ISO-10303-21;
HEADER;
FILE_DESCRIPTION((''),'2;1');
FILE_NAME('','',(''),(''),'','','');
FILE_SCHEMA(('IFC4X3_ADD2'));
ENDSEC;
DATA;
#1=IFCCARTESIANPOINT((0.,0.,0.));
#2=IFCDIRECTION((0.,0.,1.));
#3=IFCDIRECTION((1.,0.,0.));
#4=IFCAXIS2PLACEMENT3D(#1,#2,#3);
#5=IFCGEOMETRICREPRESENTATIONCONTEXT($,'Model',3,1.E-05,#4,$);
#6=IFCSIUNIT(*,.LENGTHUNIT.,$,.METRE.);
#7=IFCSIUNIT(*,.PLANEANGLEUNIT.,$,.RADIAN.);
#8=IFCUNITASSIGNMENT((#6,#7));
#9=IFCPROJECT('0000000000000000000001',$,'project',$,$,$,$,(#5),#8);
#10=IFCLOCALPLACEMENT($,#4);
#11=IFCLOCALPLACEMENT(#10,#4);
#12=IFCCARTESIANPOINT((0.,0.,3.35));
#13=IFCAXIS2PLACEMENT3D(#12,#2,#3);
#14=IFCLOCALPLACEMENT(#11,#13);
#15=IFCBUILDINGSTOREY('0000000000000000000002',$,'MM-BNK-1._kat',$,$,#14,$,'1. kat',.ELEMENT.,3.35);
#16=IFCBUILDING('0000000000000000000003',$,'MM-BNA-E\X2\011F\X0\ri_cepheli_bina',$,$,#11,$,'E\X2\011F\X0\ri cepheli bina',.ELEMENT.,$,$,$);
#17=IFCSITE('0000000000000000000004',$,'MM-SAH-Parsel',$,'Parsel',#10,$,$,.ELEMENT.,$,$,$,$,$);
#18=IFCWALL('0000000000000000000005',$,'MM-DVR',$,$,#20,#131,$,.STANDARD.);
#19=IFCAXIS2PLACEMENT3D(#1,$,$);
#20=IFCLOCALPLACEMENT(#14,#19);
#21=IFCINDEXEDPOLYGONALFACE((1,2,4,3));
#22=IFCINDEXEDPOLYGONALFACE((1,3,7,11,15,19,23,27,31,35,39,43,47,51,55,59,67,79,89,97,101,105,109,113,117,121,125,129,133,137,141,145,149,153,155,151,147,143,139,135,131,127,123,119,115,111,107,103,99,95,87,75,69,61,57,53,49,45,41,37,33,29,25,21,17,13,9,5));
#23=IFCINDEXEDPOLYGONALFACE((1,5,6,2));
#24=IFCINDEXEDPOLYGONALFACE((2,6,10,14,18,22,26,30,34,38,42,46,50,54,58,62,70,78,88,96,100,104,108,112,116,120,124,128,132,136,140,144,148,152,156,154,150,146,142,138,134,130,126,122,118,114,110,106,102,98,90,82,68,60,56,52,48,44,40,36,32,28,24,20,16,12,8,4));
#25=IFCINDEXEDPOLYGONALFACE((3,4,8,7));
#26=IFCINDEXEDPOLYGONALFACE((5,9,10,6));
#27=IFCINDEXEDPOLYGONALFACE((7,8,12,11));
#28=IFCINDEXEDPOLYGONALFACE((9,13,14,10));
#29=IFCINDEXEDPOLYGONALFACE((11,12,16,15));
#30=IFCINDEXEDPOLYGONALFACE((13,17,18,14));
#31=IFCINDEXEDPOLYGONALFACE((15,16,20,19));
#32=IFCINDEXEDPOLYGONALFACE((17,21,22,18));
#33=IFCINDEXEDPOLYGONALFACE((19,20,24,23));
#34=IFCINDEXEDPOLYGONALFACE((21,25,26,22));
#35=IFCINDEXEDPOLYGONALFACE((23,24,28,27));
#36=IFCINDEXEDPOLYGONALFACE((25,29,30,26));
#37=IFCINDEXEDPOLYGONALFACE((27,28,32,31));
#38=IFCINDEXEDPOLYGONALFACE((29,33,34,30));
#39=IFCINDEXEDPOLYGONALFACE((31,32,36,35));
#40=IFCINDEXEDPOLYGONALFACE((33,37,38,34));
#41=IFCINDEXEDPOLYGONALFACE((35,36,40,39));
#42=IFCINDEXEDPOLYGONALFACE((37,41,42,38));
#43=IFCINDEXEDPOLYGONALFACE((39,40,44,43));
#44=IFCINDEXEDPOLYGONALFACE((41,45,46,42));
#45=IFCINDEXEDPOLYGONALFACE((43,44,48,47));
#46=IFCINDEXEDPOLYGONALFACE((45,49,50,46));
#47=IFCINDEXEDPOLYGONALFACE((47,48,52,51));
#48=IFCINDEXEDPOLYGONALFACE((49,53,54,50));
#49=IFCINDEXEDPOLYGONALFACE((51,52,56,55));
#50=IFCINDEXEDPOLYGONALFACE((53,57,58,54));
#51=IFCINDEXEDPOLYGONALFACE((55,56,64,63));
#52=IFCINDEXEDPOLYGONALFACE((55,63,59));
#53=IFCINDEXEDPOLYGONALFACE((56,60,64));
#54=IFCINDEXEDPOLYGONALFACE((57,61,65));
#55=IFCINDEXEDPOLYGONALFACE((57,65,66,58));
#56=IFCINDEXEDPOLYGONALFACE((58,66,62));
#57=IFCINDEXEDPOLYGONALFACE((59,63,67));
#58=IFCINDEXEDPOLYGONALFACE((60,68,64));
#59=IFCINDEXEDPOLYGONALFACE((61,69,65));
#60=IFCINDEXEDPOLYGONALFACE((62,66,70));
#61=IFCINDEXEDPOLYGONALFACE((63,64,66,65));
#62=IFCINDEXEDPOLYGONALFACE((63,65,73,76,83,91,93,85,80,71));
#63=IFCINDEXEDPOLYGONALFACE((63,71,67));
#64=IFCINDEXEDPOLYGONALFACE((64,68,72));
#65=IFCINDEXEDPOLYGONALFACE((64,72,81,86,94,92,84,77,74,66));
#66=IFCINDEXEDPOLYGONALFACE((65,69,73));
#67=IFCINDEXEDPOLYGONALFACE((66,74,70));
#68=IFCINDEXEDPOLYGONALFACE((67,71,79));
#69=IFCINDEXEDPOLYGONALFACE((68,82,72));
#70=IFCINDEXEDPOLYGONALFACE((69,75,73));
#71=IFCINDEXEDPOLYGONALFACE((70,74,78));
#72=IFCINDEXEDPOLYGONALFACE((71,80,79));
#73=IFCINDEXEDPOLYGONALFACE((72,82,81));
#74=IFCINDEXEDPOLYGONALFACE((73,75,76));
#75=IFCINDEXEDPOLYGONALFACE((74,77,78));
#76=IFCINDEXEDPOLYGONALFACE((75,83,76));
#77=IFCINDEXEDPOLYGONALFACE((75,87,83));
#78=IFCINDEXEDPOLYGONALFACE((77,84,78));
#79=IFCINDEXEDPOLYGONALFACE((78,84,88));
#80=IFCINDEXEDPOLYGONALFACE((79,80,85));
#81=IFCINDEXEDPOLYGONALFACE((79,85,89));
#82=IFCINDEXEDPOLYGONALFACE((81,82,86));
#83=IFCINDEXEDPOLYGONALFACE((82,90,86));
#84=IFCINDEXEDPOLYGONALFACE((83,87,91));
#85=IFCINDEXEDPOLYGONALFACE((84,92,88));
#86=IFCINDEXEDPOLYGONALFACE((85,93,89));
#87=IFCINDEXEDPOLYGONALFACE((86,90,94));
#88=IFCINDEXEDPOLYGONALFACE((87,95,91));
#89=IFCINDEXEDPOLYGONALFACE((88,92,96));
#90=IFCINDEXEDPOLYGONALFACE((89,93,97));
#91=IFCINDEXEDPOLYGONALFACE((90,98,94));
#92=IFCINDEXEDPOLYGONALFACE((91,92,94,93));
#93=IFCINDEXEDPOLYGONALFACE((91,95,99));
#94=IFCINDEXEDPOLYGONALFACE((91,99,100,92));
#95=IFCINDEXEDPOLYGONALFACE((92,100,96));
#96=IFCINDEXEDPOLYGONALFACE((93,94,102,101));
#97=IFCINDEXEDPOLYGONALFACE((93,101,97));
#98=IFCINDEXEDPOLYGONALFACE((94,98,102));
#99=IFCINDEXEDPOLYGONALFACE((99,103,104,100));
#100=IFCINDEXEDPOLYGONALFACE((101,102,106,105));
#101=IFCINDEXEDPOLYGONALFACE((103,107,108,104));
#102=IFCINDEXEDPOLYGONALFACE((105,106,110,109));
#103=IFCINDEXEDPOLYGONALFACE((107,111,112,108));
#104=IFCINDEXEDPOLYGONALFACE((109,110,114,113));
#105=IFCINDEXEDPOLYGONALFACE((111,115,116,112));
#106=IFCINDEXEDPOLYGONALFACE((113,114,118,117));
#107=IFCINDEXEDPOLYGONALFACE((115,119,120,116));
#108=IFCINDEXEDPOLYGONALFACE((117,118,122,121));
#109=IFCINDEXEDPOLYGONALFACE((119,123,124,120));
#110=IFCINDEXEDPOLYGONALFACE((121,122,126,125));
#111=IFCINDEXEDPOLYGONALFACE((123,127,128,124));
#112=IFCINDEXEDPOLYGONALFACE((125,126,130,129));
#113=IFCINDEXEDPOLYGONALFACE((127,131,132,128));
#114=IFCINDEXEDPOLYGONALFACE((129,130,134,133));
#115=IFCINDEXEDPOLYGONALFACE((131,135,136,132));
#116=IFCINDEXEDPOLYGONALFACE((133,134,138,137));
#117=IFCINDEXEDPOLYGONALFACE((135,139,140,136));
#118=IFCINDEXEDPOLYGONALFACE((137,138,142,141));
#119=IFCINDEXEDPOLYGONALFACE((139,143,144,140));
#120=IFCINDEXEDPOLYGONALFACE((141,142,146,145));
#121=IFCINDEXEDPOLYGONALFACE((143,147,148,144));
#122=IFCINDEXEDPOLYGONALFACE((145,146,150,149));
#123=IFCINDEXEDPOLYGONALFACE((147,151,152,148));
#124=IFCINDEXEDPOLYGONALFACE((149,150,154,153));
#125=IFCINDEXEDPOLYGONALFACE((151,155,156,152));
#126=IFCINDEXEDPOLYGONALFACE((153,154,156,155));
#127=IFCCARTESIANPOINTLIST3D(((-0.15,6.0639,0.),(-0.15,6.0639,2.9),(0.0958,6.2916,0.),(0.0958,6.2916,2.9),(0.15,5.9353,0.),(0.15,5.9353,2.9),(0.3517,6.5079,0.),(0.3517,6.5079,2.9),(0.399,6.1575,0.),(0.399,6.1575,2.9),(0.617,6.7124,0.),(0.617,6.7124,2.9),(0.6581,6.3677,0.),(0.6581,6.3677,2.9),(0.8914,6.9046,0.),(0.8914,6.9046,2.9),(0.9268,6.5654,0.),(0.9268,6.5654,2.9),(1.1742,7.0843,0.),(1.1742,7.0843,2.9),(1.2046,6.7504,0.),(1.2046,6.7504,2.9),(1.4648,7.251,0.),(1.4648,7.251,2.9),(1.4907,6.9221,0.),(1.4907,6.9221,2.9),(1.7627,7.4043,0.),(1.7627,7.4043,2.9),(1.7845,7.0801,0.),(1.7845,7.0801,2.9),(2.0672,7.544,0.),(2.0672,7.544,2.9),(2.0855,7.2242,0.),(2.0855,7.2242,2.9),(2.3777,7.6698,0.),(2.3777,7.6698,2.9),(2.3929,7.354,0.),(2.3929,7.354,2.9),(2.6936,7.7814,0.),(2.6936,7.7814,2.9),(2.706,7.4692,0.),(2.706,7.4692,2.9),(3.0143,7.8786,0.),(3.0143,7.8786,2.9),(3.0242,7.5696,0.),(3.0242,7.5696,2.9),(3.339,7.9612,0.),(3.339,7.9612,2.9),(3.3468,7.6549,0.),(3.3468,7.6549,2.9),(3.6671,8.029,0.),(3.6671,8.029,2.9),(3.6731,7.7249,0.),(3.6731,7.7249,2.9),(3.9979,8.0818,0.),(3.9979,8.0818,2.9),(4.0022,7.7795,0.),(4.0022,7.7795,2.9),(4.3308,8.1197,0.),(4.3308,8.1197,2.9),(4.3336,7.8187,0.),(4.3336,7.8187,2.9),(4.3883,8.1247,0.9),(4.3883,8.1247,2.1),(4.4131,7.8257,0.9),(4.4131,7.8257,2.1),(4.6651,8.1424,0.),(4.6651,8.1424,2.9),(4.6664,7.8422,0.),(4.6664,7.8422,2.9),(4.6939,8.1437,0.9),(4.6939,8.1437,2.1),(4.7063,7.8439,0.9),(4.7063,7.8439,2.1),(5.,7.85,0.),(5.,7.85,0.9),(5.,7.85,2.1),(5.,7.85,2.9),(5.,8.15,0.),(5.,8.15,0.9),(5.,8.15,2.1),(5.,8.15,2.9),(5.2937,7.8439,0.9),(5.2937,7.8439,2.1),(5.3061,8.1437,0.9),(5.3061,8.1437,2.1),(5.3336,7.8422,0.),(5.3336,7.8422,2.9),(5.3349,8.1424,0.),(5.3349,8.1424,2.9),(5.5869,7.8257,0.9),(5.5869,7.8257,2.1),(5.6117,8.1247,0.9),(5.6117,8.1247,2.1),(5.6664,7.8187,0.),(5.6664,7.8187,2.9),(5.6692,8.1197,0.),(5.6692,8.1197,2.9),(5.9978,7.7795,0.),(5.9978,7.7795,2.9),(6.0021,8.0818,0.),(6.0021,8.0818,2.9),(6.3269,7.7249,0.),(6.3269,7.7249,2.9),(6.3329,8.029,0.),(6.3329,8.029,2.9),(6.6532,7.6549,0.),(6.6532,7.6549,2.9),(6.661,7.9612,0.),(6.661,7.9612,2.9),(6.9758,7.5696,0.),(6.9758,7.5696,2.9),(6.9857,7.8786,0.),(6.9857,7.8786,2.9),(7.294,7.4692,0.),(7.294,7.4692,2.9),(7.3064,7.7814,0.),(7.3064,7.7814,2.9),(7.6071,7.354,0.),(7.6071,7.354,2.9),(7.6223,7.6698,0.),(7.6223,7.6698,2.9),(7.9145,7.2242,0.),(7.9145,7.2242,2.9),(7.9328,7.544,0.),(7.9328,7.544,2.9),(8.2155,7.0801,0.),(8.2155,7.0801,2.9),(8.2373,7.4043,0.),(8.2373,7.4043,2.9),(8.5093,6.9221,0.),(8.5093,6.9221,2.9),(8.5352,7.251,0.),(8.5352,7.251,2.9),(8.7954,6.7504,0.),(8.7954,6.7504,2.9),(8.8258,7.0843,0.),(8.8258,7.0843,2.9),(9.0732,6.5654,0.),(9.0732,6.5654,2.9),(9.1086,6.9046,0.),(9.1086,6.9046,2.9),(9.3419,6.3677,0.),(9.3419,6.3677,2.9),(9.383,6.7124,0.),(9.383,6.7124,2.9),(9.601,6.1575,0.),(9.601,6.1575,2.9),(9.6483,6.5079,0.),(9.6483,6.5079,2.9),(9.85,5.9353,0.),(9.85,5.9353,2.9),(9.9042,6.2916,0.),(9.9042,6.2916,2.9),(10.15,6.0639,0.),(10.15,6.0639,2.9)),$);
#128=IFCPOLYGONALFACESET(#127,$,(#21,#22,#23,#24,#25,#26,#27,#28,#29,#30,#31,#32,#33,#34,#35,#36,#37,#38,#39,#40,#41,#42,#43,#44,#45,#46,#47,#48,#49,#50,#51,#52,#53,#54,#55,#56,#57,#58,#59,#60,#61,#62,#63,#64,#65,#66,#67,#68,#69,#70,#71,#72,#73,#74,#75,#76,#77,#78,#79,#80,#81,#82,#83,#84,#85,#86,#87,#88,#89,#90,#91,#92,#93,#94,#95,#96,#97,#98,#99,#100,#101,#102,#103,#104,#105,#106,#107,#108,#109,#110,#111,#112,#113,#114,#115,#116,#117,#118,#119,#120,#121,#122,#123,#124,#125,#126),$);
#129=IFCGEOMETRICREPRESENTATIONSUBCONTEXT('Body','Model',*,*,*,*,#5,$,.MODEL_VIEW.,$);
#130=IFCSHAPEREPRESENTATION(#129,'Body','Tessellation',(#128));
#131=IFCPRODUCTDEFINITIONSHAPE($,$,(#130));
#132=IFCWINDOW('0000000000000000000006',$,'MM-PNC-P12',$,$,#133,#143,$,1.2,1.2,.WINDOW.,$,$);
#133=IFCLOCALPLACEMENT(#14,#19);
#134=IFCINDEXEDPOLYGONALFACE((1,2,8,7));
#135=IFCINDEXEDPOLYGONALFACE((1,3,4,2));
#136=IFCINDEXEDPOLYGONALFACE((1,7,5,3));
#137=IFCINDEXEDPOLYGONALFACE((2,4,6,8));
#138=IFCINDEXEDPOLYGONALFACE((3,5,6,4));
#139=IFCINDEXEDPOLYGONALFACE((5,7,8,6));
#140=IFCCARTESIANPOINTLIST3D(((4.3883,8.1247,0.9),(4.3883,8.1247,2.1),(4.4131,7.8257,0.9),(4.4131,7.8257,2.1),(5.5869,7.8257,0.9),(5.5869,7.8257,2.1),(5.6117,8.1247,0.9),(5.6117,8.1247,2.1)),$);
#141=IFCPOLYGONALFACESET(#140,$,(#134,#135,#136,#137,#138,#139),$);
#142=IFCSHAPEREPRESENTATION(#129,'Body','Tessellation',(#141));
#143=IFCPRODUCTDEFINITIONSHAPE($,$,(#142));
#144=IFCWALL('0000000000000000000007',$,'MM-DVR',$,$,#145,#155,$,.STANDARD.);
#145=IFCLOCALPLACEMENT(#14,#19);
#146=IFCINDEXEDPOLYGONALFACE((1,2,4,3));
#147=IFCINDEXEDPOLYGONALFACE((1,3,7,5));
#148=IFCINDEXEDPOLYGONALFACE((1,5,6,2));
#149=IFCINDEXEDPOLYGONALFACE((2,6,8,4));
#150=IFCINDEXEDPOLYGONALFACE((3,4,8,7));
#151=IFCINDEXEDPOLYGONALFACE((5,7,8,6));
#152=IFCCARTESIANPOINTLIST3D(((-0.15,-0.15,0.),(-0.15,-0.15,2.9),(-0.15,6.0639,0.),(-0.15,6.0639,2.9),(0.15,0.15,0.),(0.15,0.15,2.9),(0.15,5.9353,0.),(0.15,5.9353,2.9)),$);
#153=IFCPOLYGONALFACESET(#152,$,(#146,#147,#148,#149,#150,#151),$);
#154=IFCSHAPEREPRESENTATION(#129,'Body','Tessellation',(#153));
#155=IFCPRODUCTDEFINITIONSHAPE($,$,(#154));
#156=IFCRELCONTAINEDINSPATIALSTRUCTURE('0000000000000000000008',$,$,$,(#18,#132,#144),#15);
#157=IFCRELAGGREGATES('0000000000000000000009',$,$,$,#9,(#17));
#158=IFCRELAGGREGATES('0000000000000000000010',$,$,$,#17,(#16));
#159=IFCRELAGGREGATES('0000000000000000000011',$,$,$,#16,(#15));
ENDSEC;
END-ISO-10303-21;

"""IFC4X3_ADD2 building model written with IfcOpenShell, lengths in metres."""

from ifc_helpers import new_model, si_unit, frame, origin, origin_with_axes, place, context, subcontext, project, spatial, polyline, line, arc, indexed_curve, outline, extrude, element, fill, save


model = new_model("IFC4X3_ADD2")

# Units and contexts
model_context = context("Model", 3, precision=1e-05, world=origin_with_axes())
body_context = subcontext(model_context, "Body", "Model", "MODEL_VIEW")
ifc_project = project(units=[si_unit("LENGTHUNIT", "METRE"), si_unit("PLANEANGLEUNIT", "RADIAN")], contexts=[model_context])

# Site, building, storey
site_placement = place(None, origin_with_axes())
site = spatial("IfcSite", under=ifc_project, at=site_placement, Name="MM-SAH-Parsel", ObjectType="Parsel", CompositionType="ELEMENT")
building_placement = place(site_placement, origin_with_axes())
building = spatial("IfcBuilding", under=site, at=building_placement, Name="MM-BNA-Eğri_cepheli_bina", LongName="Eğri cepheli bina", CompositionType="ELEMENT")
storey_placement = place(building_placement, frame((0.0, 0.0, 3.35), z_axis=(0.0, 0.0, 1.0), x_axis=(1.0, 0.0, 0.0)))
storey = spatial("IfcBuildingStorey", under=building, at=storey_placement, Name="MM-BNK-1._kat", LongName="1. kat", CompositionType="ELEMENT", Elevation=3.35)

# Wall, opening, window
wall_1_placement = place(storey_placement, origin_with_axes())
wall_1 = element("IfcWall", 1, at=wall_1_placement, inside=storey, Name="MM-DVR", PredefinedType="STANDARD", context=body_context, shape_type="SweptSolid", body=[
    extrude(outline(indexed_curve([(9.85, 5.9353), (5.0, 7.85), (0.15, 5.9353), (-0.15, 6.0639), (5.0, 8.15), (10.15, 6.0639)], segments=[arc(1, 2, 3), line(3, 4), arc(4, 5, 6), line(6, 1)], self_intersect=False)), origin(), (0.0, 0.0, 1.0), 2.9),
])
opening_1_placement = place(storey_placement, origin_with_axes())
opening_1 = element("IfcOpeningElement", 2, at=opening_1_placement, cuts=wall_1, PredefinedType="OPENING", context=body_context, shape_type="SweptSolid", body=[
    extrude(outline(indexed_curve([(5.5869, 7.8257), (5.0, 7.85), (4.4131, 7.8257), (4.3883, 8.1247), (5.0, 8.15), (5.6117, 8.1247)], segments=[arc(1, 2, 3), line(3, 4), arc(4, 5, 6), line(6, 1)], self_intersect=False)), frame((0.0, 0.0, 0.9)), (0.0, 0.0, 1.0), 1.2),
])
window_1_placement = place(storey_placement, origin_with_axes())
window_1 = element("IfcWindow", 3, at=window_1_placement, inside=storey, Name="MM-PNC-P12", OverallHeight=1.2, OverallWidth=1.2, PredefinedType="WINDOW", context=body_context, shape_type="SweptSolid", body=[
    extrude(outline(polyline([(5.5869, 7.8257), (4.4131, 7.8257), (4.3883, 8.1247), (5.6117, 8.1247), (5.5869, 7.8257)])), frame((0.0, 0.0, 0.9)), (0.0, 0.0, 1.0), 1.2),
])
fill(opening_1, window_1)

# Wall
wall_2_placement = place(storey_placement, origin_with_axes())
element("IfcWall", 4, at=wall_2_placement, inside=storey, Name="MM-DVR", PredefinedType="STANDARD", context=body_context, shape_type="SweptSolid", body=[
    extrude(outline(polyline([(0.15, 5.9353), (0.15, 0.15), (-0.15, -0.15), (-0.15, 6.0639), (0.15, 5.9353)])), origin(), (0.0, 0.0, 1.0), 2.9),
])

save(model, "model.ifc")
